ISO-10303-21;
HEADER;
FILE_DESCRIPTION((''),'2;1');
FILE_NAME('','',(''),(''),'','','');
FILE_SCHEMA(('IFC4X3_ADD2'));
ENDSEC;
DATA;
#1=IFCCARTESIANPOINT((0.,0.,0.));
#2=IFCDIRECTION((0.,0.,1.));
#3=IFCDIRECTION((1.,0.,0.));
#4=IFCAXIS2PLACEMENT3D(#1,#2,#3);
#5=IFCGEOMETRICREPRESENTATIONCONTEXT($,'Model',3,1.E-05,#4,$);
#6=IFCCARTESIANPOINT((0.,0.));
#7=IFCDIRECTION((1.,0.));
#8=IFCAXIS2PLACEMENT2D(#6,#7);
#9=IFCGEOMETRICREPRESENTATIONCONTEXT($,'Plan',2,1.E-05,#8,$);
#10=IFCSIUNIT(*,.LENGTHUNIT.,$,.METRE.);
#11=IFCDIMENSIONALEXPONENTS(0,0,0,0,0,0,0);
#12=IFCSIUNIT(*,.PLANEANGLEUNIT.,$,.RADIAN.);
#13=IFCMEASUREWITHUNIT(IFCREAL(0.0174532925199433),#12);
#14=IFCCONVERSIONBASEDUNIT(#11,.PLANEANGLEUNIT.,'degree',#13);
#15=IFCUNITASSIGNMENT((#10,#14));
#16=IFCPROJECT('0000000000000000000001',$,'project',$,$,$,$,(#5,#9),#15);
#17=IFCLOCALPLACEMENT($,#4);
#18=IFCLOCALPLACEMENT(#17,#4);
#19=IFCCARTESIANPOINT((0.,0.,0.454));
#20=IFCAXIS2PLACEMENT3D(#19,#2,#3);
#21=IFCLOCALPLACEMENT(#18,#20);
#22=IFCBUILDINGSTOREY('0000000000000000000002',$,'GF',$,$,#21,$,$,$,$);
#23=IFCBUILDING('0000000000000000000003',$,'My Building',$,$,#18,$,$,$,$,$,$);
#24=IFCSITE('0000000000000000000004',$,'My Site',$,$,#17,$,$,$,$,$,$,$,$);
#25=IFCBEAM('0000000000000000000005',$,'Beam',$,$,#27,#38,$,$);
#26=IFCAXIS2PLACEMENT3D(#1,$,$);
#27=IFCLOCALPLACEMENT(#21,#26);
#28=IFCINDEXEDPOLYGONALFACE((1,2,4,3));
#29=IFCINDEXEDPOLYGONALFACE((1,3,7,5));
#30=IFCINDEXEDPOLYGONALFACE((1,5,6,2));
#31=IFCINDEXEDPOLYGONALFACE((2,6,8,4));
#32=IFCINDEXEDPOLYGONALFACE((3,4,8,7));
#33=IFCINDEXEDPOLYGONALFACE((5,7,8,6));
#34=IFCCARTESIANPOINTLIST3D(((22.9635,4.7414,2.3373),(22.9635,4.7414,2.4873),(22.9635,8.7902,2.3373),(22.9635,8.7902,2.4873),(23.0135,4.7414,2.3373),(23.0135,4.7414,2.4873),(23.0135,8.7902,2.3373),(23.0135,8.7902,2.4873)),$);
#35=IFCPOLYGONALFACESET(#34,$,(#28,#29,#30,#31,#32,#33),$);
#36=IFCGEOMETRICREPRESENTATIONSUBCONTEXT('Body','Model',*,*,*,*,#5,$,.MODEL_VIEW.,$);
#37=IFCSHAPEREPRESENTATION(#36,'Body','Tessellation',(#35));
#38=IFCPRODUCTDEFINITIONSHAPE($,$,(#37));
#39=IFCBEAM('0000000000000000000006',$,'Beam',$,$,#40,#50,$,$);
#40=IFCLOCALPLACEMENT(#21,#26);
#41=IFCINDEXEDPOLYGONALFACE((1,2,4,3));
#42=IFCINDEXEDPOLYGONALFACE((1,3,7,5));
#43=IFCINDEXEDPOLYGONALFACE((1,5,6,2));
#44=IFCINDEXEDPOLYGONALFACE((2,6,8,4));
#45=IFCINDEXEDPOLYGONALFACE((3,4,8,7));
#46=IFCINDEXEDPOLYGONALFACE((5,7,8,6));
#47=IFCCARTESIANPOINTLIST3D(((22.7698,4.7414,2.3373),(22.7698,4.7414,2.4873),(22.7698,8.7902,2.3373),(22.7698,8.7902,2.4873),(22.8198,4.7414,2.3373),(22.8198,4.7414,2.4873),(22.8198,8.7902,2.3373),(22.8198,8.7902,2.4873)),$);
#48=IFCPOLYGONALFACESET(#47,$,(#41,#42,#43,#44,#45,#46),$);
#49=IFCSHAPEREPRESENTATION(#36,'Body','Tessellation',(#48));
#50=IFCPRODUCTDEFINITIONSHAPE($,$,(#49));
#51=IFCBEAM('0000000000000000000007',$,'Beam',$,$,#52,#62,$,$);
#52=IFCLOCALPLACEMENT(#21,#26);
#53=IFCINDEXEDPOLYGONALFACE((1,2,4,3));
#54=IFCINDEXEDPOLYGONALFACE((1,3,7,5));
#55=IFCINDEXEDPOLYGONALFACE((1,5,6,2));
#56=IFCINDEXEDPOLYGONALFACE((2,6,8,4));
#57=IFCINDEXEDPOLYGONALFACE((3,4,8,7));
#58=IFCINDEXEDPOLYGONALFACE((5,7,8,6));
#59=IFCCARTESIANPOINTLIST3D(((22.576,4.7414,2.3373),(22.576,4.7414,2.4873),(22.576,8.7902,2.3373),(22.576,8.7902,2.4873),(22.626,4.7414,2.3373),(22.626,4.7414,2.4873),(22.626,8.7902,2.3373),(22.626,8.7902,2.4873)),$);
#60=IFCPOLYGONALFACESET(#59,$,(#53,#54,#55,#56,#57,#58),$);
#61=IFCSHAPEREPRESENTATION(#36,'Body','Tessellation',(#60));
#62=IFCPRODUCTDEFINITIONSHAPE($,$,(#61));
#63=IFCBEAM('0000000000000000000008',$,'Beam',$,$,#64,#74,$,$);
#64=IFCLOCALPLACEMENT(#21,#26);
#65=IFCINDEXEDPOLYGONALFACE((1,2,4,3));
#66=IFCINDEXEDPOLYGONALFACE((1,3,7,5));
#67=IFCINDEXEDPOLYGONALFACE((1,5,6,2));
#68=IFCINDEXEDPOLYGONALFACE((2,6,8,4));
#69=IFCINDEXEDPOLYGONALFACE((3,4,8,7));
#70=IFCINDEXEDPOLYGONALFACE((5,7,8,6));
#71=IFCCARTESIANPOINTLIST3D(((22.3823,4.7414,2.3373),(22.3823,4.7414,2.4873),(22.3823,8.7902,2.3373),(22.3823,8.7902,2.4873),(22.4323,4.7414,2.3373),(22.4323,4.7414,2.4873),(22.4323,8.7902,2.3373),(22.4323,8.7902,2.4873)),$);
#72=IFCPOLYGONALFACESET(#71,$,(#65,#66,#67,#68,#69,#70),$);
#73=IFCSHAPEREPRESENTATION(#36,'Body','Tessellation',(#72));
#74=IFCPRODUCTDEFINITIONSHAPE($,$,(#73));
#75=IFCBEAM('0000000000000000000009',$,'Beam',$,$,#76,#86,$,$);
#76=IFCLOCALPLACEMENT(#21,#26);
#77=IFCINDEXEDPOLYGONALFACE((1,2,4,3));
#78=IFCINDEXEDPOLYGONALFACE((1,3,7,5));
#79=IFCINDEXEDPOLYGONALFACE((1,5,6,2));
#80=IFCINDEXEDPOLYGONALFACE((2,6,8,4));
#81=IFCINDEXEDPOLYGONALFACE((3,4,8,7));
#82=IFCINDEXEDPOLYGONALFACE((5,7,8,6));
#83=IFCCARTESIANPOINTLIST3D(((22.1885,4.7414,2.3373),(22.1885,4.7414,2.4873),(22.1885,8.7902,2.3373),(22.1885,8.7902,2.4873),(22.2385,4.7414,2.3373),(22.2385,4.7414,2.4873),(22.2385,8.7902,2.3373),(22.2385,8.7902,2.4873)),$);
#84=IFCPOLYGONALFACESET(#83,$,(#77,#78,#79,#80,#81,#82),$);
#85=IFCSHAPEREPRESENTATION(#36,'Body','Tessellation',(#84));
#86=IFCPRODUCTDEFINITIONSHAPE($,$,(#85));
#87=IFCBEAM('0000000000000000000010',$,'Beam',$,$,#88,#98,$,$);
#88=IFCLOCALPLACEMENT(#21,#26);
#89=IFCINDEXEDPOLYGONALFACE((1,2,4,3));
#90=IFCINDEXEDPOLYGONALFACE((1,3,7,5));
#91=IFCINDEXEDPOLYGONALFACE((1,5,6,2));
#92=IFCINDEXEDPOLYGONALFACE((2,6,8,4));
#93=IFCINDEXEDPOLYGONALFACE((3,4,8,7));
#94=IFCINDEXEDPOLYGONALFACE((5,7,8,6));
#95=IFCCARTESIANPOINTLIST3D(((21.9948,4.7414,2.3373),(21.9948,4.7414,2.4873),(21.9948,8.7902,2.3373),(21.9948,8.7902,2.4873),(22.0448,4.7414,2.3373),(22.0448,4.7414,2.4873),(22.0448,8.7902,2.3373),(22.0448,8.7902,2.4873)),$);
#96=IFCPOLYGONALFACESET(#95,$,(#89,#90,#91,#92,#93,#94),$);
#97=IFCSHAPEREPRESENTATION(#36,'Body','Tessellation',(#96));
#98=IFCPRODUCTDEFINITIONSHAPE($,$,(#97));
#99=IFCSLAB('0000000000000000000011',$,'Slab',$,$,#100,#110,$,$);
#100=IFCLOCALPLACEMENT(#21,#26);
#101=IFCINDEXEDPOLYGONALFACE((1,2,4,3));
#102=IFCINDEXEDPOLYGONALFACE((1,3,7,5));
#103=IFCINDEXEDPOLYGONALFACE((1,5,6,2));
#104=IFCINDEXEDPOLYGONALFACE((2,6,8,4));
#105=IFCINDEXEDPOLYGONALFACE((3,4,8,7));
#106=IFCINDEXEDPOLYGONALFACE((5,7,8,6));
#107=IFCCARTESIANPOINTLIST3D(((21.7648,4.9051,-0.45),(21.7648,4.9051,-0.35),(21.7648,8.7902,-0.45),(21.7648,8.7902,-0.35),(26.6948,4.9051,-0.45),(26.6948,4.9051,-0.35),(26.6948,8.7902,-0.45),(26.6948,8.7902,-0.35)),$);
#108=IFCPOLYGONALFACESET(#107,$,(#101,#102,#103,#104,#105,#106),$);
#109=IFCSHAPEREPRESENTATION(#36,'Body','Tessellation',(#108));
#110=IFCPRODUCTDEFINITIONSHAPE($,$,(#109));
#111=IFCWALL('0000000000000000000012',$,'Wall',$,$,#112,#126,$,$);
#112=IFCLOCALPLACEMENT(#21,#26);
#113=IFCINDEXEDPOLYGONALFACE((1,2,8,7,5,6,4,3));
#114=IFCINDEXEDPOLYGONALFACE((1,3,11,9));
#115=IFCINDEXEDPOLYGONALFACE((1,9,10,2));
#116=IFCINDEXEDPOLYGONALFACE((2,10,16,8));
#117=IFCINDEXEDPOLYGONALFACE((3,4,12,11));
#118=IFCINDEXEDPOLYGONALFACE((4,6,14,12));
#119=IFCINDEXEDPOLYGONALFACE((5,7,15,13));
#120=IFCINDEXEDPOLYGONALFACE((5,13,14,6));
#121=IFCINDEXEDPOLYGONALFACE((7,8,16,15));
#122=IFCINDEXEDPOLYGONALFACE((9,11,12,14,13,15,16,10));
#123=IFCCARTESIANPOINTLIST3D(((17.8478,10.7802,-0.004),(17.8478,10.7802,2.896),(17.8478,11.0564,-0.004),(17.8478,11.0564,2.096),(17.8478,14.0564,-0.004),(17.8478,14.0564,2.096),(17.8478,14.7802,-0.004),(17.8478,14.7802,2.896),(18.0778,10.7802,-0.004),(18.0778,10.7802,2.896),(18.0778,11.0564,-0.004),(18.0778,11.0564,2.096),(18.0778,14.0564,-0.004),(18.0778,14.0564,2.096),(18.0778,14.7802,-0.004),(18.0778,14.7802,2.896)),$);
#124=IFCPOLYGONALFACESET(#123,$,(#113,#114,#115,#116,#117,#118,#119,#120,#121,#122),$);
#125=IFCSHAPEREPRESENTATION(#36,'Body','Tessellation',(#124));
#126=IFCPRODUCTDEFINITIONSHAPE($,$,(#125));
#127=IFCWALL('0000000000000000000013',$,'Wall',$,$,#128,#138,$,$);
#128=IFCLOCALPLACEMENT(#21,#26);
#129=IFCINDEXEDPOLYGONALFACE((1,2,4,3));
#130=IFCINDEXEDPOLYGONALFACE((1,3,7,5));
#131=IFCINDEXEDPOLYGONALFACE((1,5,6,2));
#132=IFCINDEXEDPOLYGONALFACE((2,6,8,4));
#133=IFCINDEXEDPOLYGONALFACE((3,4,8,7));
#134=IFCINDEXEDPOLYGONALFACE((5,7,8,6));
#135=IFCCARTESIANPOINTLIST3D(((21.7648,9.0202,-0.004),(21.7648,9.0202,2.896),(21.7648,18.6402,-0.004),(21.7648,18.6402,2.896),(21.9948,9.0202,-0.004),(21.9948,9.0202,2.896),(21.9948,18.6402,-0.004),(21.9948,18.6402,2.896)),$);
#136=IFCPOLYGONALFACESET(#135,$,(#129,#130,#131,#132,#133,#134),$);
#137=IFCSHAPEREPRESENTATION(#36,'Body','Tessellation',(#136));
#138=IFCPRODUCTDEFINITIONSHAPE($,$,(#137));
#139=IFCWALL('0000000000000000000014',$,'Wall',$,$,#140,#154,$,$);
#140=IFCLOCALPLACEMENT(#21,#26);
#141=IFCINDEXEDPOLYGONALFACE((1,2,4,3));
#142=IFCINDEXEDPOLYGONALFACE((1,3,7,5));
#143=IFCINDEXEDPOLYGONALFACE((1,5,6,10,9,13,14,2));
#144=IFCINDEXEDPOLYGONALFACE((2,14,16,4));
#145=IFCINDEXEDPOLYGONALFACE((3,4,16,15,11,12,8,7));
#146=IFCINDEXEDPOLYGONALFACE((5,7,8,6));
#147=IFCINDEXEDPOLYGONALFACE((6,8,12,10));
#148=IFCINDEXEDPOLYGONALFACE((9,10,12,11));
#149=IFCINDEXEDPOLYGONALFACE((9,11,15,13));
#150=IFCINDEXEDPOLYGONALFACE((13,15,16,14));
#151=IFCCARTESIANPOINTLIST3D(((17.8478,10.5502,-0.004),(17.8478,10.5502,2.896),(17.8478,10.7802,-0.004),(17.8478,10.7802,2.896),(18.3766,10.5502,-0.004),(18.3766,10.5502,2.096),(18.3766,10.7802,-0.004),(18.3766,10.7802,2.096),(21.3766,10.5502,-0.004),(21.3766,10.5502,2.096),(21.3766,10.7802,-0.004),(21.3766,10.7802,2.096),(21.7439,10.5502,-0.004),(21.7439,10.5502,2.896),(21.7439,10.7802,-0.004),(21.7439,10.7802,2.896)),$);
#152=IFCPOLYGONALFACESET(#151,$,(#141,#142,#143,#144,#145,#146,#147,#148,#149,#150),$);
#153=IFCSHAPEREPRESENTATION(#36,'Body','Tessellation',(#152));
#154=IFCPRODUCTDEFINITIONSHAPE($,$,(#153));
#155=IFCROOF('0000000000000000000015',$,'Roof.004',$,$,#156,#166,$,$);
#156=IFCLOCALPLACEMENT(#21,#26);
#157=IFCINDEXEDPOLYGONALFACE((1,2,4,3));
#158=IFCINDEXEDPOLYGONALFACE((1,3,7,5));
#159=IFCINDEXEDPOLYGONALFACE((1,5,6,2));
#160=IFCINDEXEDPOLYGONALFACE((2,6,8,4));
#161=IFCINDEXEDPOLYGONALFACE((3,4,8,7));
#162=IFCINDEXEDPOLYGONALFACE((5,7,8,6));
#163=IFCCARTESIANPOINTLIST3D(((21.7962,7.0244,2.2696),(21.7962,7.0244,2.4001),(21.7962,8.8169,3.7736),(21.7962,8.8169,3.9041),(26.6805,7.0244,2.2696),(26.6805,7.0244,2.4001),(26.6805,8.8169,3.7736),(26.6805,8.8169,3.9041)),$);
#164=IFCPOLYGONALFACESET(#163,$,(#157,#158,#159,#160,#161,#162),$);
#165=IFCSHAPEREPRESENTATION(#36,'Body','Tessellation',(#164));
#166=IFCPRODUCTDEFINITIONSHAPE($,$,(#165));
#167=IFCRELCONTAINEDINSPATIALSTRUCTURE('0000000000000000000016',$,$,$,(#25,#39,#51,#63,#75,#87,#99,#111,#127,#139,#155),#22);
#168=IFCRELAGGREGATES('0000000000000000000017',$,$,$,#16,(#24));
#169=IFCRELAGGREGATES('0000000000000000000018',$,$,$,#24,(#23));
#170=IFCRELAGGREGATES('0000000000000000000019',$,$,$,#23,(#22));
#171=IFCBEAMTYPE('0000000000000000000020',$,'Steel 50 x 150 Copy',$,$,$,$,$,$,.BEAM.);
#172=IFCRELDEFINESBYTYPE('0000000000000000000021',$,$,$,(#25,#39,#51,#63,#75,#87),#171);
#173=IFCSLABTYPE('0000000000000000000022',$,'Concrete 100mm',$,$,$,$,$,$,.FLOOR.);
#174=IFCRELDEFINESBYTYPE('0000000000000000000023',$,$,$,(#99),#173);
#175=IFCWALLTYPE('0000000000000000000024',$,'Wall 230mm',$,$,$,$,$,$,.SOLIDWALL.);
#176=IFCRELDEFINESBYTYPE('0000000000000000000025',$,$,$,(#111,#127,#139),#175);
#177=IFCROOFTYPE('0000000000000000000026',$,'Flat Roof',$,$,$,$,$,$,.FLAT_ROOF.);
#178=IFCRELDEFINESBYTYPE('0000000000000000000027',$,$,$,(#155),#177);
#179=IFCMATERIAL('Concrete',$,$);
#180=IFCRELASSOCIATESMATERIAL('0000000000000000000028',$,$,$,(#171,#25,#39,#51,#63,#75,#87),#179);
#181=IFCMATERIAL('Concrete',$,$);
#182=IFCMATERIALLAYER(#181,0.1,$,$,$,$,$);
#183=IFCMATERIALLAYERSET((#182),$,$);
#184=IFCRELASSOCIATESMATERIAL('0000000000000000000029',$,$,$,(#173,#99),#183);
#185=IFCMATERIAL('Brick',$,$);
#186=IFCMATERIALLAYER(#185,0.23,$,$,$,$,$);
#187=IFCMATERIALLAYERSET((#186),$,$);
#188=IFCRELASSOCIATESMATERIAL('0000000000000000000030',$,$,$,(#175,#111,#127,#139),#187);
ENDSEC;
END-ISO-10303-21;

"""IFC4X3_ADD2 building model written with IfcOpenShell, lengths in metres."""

from ifc_helpers import new_model, entity, si_unit, converted_unit, frame, origin_with_axes, origin_2d_with_axis, place, context, subcontext, project, spatial, polyline, line, indexed_curve, rectangle, outline, extrude, source, transform, mapped, material, layer, layer_set, layer_usage, material_profile, profile_set, profile_usage, type_object, element, save


model = new_model("IFC4X3_ADD2")

# Units and contexts
model_context = context("Model", 3, precision=1e-05, world=origin_with_axes())
plan_context = context("Plan", 2, precision=1e-05, world=origin_2d_with_axis())
body_context_1 = subcontext(model_context, "Body", "Model", "MODEL_VIEW")
ifc_project = project(units=[si_unit("LENGTHUNIT", "METRE"), converted_unit("PLANEANGLEUNIT", "degree", entity("IfcReal", 0.0174532925199433), si_unit("PLANEANGLEUNIT", "RADIAN"), dimensions=[0, 0, 0, 0, 0, 0, 0])], contexts=[model_context, plan_context])

# Site, building, storey
site_placement = place(None, origin_with_axes())
site = spatial("IfcSite", under=ifc_project, at=site_placement, Name="My Site")
building_placement = place(site_placement, origin_with_axes())
building = spatial("IfcBuilding", under=site, at=building_placement, Name="My Building")
storey_placement = place(building_placement, frame((0.0, 0.0, 0.454), z_axis=(0.0, 0.0, 1.0), x_axis=(1.0, 0.0, 0.0)))
storey = spatial("IfcBuildingStorey", under=building, at=storey_placement, Name="GF")

# Beams
ifc_material_1 = material(Name="Concrete")
ifc_material_profile_1 = material_profile(ifc_material_1, rectangle(XDim=0.05, YDim=0.15))
ifc_profile_set_1 = profile_set([ifc_material_profile_1])
beam_type_1 = type_object("IfcBeamType", Name="Steel 50 x 150 Copy", PredefinedType="BEAM", material=ifc_profile_set_1)
ifc_profile_usage_1 = profile_usage(ifc_profile_set_1)
beam_1_placement = place(storey_placement, frame((22.9885, 8.7902, 2.4123), z_axis=(0.0, -1.0, 0.0), x_axis=(1.0, 0.0, 0.0)))
element("IfcBeam", 1, at=beam_1_placement, inside=storey, type_object=beam_type_1, material=ifc_profile_usage_1, Name="Beam", context=body_context_1, shape_type="SweptSolid", body=[
    extrude(rectangle(XDim=0.05, YDim=0.15), origin_with_axes(), (0.0, 0.0, 1.0), 4.0488),
])
ifc_profile_usage_2 = profile_usage(ifc_profile_set_1)
beam_2_placement = place(storey_placement, frame((22.7948, 8.7902, 2.4123), z_axis=(0.0, -1.0, 0.0), x_axis=(1.0, 0.0, 0.0)))
element("IfcBeam", 2, at=beam_2_placement, inside=storey, type_object=beam_type_1, material=ifc_profile_usage_2, Name="Beam", context=body_context_1, shape_type="SweptSolid", body=[
    extrude(rectangle(XDim=0.05, YDim=0.15), origin_with_axes(), (0.0, 0.0, 1.0), 4.0488),
])
ifc_profile_usage_3 = profile_usage(ifc_profile_set_1)
beam_3_placement = place(storey_placement, frame((22.601, 8.7902, 2.4123), z_axis=(0.0, -1.0, 0.0), x_axis=(1.0, 0.0, 0.0)))
element("IfcBeam", 3, at=beam_3_placement, inside=storey, type_object=beam_type_1, material=ifc_profile_usage_3, Name="Beam", context=body_context_1, shape_type="SweptSolid", body=[
    extrude(rectangle(XDim=0.05, YDim=0.15), origin_with_axes(), (0.0, 0.0, 1.0), 4.0488),
])
ifc_profile_usage_4 = profile_usage(ifc_profile_set_1)
beam_4_placement = place(storey_placement, frame((22.4073, 8.7902, 2.4123), z_axis=(0.0, -1.0, 0.0), x_axis=(1.0, 0.0, 0.0)))
element("IfcBeam", 4, at=beam_4_placement, inside=storey, type_object=beam_type_1, material=ifc_profile_usage_4, Name="Beam", context=body_context_1, shape_type="SweptSolid", body=[
    extrude(rectangle(XDim=0.05, YDim=0.15), origin_with_axes(), (0.0, 0.0, 1.0), 4.0488),
])
ifc_profile_usage_5 = profile_usage(ifc_profile_set_1)
beam_5_placement = place(storey_placement, frame((22.2135, 8.7902, 2.4123), z_axis=(0.0, -1.0, 0.0), x_axis=(1.0, 0.0, 0.0)))
element("IfcBeam", 5, at=beam_5_placement, inside=storey, type_object=beam_type_1, material=ifc_profile_usage_5, Name="Beam", context=body_context_1, shape_type="SweptSolid", body=[
    extrude(rectangle(XDim=0.05, YDim=0.15), origin_with_axes(), (0.0, 0.0, 1.0), 4.0488),
])
ifc_profile_usage_6 = profile_usage(ifc_profile_set_1)
beam_6_placement = place(storey_placement, frame((22.0198, 8.7902, 2.4123), z_axis=(0.0, -1.0, 0.0), x_axis=(1.0, 0.0, 0.0)))
element("IfcBeam", 6, at=beam_6_placement, inside=storey, type_object=beam_type_1, material=ifc_profile_usage_6, Name="Beam", context=body_context_1, shape_type="SweptSolid", body=[
    extrude(rectangle(XDim=0.05, YDim=0.15), origin_with_axes(), (0.0, 0.0, 1.0), 4.0488),
])

# Slab
ifc_material_2 = material(Name="Concrete")
ifc_layer_1 = layer(ifc_material_2, 0.1)
ifc_layer_set_1 = layer_set([ifc_layer_1])
ifc_layer_usage_1 = layer_usage(ifc_layer_set_1, "AXIS3", "POSITIVE", 0.0)
slab_type = type_object("IfcSlabType", Name="Concrete 100mm", PredefinedType="FLOOR", material=ifc_layer_set_1)
slab_placement = place(storey_placement, frame((21.7648, 4.9051, -0.45), z_axis=(0.0, 0.0, 1.0), x_axis=(1.0, 0.0, 0.0)))
element("IfcSlab", 7, at=slab_placement, inside=storey, type_object=slab_type, material=ifc_layer_usage_1, Name="Slab", context=body_context_1, shape_type="SweptSolid", body=[
    extrude(outline(indexed_curve([(4.93, 3.8851), (4.93, 0.0), (0.0, 0.0), (0.0, 3.8851)], segments=[line(4, 1), line(1, 2), line(2, 3), line(3, 4)], self_intersect=False)), None, (0.0, 0.0, 1.0), 0.1),
])

# Wall, opening
ifc_material_3 = material(Name="Brick")
ifc_layer_2 = layer(ifc_material_3, 0.23)
ifc_layer_set_2 = layer_set([ifc_layer_2])
ifc_layer_usage_2 = layer_usage(ifc_layer_set_2, "AXIS2", "POSITIVE", 0.0)
wall_type = type_object("IfcWallType", Name="Wall 230mm", PredefinedType="SOLIDWALL", material=ifc_layer_set_2)
wall_1_placement = place(storey_placement, frame((18.0778, 10.7802, -0.004), z_axis=(0.0, 0.0, 1.0), x_axis=(0.000001, 1.0, 0.0)))
wall_1 = element("IfcWall", 8, at=wall_1_placement, inside=storey, type_object=wall_type, material=ifc_layer_usage_2, Name="Wall", context=body_context_1, shape_type="SweptSolid", body=[
    extrude(outline(indexed_curve([(0.0, 0.0), (0.0, 0.23), (4.0, 0.23), (4.0, 0.0), (0.0, 0.0)], self_intersect=False)), origin_with_axes(), (0.0, 0.0, 1.0), 2.9),
])
shared_shape_1 = source(origin_with_axes(), body_context_1, "Body", "SweptSolid", [
    extrude(outline(indexed_curve([(0.0, 0.0), (3.0, 0.0), (3.0, 2.1), (0.0, 2.1)], segments=[line(1, 2, 3, 4, 1)])), frame((0.0, -0.6, 0.0), z_axis=(0.0, -1.0, 0.0), x_axis=(1.0, 0.0, 0.0)), (0.0, 0.0, -1.0), 1.2),
])
opening_1_placement = place(wall_1_placement, frame((0.2763, 0.0, 0.0), z_axis=(0.0, 0.0, 1.0), x_axis=(1.0, 0.0, 0.0)))
element("IfcOpeningElement", 9, at=opening_1_placement, cuts=wall_1, PredefinedType="OPENING", context=body_context_1, shape_type="MappedRepresentation", body=[
    mapped(shared_shape_1, transform((0.0, 0.0, 0.0), x_axis=(1.0, 0.0, 0.0), y_axis=(0.0, 1.0, 0.0), z_axis=(0.0, 0.0, 1.0), scale=1.0)),
])

# Wall
ifc_layer_usage_3 = layer_usage(ifc_layer_set_2, "AXIS2", "POSITIVE", 0.0)
wall_2_placement = place(storey_placement, frame((21.9948, 9.0202, -0.004), z_axis=(0.0, 0.0, 1.0), x_axis=(0.000001, 1.0, 0.0)))
element("IfcWall", 10, at=wall_2_placement, inside=storey, type_object=wall_type, material=ifc_layer_usage_3, Name="Wall", context=body_context_1, shape_type="SweptSolid", body=[
    extrude(outline(indexed_curve([(0.0, 0.0), (0.0, 0.23), (9.62, 0.23), (9.62, 0.0), (0.0, 0.0)], self_intersect=False)), origin_with_axes(), (0.0, 0.0, 1.0), 2.9),
])

# Wall, opening
ifc_layer_usage_4 = layer_usage(ifc_layer_set_2, "AXIS2", "POSITIVE", 0.0)
wall_3_placement = place(storey_placement, frame((21.7439, 10.7802, -0.004), z_axis=(0.0, 0.0, 1.0), x_axis=(-1.0, 0.0, 0.0)))
wall_3 = element("IfcWall", 11, at=wall_3_placement, inside=storey, type_object=wall_type, material=ifc_layer_usage_4, Name="Wall", context=body_context_1, shape_type="SweptSolid", body=[
    extrude(outline(indexed_curve([(0.0, 0.0), (0.0, 0.23), (3.8962, 0.23), (3.8962, 0.0), (0.0, 0.0)], self_intersect=False)), origin_with_axes(), (0.0, 0.0, 1.0), 2.9),
])
opening_2_placement = place(wall_3_placement, frame((0.3674, 0.0, 0.0), z_axis=(0.0, 0.0, 1.0), x_axis=(1.0, 0.0, 0.0)))
element("IfcOpeningElement", 12, at=opening_2_placement, cuts=wall_3, PredefinedType="OPENING", context=body_context_1, shape_type="MappedRepresentation", body=[
    mapped(shared_shape_1, transform((0.0, 0.0, 0.0), x_axis=(1.0, 0.0, 0.0), y_axis=(0.0, 1.0, 0.0), z_axis=(0.0, 0.0, 1.0), scale=1.0)),
])

# Roof
roof_type = type_object("IfcRoofType", Name="Flat Roof", PredefinedType="FLAT_ROOF")
roof_placement = place(storey_placement, frame((21.7962, 8.0241, 3.1084), z_axis=(0.0, -0.642788, 0.766044), x_axis=(1.0, 0.0, 0.0)))
element("IfcRoof", 13, at=roof_placement, inside=storey, type_object=roof_type, Name="Roof.004", context=body_context_1, shape_type="SweptSolid", body=[
    extrude(outline(polyline([(-2.4421, -0.0653), (2.4421, -0.0653), (2.4421, 0.0653), (-2.4421, 0.0653), (-2.4421, -0.0653)])), frame((2.4421, 1.0768, 0.05), z_axis=(0.0, 0.766044, -0.642788), x_axis=(1.0, 0.0, 0.0)), (0.0, 0.642788, -0.766044), 2.3398),
])

save(model, "model.ifc")
